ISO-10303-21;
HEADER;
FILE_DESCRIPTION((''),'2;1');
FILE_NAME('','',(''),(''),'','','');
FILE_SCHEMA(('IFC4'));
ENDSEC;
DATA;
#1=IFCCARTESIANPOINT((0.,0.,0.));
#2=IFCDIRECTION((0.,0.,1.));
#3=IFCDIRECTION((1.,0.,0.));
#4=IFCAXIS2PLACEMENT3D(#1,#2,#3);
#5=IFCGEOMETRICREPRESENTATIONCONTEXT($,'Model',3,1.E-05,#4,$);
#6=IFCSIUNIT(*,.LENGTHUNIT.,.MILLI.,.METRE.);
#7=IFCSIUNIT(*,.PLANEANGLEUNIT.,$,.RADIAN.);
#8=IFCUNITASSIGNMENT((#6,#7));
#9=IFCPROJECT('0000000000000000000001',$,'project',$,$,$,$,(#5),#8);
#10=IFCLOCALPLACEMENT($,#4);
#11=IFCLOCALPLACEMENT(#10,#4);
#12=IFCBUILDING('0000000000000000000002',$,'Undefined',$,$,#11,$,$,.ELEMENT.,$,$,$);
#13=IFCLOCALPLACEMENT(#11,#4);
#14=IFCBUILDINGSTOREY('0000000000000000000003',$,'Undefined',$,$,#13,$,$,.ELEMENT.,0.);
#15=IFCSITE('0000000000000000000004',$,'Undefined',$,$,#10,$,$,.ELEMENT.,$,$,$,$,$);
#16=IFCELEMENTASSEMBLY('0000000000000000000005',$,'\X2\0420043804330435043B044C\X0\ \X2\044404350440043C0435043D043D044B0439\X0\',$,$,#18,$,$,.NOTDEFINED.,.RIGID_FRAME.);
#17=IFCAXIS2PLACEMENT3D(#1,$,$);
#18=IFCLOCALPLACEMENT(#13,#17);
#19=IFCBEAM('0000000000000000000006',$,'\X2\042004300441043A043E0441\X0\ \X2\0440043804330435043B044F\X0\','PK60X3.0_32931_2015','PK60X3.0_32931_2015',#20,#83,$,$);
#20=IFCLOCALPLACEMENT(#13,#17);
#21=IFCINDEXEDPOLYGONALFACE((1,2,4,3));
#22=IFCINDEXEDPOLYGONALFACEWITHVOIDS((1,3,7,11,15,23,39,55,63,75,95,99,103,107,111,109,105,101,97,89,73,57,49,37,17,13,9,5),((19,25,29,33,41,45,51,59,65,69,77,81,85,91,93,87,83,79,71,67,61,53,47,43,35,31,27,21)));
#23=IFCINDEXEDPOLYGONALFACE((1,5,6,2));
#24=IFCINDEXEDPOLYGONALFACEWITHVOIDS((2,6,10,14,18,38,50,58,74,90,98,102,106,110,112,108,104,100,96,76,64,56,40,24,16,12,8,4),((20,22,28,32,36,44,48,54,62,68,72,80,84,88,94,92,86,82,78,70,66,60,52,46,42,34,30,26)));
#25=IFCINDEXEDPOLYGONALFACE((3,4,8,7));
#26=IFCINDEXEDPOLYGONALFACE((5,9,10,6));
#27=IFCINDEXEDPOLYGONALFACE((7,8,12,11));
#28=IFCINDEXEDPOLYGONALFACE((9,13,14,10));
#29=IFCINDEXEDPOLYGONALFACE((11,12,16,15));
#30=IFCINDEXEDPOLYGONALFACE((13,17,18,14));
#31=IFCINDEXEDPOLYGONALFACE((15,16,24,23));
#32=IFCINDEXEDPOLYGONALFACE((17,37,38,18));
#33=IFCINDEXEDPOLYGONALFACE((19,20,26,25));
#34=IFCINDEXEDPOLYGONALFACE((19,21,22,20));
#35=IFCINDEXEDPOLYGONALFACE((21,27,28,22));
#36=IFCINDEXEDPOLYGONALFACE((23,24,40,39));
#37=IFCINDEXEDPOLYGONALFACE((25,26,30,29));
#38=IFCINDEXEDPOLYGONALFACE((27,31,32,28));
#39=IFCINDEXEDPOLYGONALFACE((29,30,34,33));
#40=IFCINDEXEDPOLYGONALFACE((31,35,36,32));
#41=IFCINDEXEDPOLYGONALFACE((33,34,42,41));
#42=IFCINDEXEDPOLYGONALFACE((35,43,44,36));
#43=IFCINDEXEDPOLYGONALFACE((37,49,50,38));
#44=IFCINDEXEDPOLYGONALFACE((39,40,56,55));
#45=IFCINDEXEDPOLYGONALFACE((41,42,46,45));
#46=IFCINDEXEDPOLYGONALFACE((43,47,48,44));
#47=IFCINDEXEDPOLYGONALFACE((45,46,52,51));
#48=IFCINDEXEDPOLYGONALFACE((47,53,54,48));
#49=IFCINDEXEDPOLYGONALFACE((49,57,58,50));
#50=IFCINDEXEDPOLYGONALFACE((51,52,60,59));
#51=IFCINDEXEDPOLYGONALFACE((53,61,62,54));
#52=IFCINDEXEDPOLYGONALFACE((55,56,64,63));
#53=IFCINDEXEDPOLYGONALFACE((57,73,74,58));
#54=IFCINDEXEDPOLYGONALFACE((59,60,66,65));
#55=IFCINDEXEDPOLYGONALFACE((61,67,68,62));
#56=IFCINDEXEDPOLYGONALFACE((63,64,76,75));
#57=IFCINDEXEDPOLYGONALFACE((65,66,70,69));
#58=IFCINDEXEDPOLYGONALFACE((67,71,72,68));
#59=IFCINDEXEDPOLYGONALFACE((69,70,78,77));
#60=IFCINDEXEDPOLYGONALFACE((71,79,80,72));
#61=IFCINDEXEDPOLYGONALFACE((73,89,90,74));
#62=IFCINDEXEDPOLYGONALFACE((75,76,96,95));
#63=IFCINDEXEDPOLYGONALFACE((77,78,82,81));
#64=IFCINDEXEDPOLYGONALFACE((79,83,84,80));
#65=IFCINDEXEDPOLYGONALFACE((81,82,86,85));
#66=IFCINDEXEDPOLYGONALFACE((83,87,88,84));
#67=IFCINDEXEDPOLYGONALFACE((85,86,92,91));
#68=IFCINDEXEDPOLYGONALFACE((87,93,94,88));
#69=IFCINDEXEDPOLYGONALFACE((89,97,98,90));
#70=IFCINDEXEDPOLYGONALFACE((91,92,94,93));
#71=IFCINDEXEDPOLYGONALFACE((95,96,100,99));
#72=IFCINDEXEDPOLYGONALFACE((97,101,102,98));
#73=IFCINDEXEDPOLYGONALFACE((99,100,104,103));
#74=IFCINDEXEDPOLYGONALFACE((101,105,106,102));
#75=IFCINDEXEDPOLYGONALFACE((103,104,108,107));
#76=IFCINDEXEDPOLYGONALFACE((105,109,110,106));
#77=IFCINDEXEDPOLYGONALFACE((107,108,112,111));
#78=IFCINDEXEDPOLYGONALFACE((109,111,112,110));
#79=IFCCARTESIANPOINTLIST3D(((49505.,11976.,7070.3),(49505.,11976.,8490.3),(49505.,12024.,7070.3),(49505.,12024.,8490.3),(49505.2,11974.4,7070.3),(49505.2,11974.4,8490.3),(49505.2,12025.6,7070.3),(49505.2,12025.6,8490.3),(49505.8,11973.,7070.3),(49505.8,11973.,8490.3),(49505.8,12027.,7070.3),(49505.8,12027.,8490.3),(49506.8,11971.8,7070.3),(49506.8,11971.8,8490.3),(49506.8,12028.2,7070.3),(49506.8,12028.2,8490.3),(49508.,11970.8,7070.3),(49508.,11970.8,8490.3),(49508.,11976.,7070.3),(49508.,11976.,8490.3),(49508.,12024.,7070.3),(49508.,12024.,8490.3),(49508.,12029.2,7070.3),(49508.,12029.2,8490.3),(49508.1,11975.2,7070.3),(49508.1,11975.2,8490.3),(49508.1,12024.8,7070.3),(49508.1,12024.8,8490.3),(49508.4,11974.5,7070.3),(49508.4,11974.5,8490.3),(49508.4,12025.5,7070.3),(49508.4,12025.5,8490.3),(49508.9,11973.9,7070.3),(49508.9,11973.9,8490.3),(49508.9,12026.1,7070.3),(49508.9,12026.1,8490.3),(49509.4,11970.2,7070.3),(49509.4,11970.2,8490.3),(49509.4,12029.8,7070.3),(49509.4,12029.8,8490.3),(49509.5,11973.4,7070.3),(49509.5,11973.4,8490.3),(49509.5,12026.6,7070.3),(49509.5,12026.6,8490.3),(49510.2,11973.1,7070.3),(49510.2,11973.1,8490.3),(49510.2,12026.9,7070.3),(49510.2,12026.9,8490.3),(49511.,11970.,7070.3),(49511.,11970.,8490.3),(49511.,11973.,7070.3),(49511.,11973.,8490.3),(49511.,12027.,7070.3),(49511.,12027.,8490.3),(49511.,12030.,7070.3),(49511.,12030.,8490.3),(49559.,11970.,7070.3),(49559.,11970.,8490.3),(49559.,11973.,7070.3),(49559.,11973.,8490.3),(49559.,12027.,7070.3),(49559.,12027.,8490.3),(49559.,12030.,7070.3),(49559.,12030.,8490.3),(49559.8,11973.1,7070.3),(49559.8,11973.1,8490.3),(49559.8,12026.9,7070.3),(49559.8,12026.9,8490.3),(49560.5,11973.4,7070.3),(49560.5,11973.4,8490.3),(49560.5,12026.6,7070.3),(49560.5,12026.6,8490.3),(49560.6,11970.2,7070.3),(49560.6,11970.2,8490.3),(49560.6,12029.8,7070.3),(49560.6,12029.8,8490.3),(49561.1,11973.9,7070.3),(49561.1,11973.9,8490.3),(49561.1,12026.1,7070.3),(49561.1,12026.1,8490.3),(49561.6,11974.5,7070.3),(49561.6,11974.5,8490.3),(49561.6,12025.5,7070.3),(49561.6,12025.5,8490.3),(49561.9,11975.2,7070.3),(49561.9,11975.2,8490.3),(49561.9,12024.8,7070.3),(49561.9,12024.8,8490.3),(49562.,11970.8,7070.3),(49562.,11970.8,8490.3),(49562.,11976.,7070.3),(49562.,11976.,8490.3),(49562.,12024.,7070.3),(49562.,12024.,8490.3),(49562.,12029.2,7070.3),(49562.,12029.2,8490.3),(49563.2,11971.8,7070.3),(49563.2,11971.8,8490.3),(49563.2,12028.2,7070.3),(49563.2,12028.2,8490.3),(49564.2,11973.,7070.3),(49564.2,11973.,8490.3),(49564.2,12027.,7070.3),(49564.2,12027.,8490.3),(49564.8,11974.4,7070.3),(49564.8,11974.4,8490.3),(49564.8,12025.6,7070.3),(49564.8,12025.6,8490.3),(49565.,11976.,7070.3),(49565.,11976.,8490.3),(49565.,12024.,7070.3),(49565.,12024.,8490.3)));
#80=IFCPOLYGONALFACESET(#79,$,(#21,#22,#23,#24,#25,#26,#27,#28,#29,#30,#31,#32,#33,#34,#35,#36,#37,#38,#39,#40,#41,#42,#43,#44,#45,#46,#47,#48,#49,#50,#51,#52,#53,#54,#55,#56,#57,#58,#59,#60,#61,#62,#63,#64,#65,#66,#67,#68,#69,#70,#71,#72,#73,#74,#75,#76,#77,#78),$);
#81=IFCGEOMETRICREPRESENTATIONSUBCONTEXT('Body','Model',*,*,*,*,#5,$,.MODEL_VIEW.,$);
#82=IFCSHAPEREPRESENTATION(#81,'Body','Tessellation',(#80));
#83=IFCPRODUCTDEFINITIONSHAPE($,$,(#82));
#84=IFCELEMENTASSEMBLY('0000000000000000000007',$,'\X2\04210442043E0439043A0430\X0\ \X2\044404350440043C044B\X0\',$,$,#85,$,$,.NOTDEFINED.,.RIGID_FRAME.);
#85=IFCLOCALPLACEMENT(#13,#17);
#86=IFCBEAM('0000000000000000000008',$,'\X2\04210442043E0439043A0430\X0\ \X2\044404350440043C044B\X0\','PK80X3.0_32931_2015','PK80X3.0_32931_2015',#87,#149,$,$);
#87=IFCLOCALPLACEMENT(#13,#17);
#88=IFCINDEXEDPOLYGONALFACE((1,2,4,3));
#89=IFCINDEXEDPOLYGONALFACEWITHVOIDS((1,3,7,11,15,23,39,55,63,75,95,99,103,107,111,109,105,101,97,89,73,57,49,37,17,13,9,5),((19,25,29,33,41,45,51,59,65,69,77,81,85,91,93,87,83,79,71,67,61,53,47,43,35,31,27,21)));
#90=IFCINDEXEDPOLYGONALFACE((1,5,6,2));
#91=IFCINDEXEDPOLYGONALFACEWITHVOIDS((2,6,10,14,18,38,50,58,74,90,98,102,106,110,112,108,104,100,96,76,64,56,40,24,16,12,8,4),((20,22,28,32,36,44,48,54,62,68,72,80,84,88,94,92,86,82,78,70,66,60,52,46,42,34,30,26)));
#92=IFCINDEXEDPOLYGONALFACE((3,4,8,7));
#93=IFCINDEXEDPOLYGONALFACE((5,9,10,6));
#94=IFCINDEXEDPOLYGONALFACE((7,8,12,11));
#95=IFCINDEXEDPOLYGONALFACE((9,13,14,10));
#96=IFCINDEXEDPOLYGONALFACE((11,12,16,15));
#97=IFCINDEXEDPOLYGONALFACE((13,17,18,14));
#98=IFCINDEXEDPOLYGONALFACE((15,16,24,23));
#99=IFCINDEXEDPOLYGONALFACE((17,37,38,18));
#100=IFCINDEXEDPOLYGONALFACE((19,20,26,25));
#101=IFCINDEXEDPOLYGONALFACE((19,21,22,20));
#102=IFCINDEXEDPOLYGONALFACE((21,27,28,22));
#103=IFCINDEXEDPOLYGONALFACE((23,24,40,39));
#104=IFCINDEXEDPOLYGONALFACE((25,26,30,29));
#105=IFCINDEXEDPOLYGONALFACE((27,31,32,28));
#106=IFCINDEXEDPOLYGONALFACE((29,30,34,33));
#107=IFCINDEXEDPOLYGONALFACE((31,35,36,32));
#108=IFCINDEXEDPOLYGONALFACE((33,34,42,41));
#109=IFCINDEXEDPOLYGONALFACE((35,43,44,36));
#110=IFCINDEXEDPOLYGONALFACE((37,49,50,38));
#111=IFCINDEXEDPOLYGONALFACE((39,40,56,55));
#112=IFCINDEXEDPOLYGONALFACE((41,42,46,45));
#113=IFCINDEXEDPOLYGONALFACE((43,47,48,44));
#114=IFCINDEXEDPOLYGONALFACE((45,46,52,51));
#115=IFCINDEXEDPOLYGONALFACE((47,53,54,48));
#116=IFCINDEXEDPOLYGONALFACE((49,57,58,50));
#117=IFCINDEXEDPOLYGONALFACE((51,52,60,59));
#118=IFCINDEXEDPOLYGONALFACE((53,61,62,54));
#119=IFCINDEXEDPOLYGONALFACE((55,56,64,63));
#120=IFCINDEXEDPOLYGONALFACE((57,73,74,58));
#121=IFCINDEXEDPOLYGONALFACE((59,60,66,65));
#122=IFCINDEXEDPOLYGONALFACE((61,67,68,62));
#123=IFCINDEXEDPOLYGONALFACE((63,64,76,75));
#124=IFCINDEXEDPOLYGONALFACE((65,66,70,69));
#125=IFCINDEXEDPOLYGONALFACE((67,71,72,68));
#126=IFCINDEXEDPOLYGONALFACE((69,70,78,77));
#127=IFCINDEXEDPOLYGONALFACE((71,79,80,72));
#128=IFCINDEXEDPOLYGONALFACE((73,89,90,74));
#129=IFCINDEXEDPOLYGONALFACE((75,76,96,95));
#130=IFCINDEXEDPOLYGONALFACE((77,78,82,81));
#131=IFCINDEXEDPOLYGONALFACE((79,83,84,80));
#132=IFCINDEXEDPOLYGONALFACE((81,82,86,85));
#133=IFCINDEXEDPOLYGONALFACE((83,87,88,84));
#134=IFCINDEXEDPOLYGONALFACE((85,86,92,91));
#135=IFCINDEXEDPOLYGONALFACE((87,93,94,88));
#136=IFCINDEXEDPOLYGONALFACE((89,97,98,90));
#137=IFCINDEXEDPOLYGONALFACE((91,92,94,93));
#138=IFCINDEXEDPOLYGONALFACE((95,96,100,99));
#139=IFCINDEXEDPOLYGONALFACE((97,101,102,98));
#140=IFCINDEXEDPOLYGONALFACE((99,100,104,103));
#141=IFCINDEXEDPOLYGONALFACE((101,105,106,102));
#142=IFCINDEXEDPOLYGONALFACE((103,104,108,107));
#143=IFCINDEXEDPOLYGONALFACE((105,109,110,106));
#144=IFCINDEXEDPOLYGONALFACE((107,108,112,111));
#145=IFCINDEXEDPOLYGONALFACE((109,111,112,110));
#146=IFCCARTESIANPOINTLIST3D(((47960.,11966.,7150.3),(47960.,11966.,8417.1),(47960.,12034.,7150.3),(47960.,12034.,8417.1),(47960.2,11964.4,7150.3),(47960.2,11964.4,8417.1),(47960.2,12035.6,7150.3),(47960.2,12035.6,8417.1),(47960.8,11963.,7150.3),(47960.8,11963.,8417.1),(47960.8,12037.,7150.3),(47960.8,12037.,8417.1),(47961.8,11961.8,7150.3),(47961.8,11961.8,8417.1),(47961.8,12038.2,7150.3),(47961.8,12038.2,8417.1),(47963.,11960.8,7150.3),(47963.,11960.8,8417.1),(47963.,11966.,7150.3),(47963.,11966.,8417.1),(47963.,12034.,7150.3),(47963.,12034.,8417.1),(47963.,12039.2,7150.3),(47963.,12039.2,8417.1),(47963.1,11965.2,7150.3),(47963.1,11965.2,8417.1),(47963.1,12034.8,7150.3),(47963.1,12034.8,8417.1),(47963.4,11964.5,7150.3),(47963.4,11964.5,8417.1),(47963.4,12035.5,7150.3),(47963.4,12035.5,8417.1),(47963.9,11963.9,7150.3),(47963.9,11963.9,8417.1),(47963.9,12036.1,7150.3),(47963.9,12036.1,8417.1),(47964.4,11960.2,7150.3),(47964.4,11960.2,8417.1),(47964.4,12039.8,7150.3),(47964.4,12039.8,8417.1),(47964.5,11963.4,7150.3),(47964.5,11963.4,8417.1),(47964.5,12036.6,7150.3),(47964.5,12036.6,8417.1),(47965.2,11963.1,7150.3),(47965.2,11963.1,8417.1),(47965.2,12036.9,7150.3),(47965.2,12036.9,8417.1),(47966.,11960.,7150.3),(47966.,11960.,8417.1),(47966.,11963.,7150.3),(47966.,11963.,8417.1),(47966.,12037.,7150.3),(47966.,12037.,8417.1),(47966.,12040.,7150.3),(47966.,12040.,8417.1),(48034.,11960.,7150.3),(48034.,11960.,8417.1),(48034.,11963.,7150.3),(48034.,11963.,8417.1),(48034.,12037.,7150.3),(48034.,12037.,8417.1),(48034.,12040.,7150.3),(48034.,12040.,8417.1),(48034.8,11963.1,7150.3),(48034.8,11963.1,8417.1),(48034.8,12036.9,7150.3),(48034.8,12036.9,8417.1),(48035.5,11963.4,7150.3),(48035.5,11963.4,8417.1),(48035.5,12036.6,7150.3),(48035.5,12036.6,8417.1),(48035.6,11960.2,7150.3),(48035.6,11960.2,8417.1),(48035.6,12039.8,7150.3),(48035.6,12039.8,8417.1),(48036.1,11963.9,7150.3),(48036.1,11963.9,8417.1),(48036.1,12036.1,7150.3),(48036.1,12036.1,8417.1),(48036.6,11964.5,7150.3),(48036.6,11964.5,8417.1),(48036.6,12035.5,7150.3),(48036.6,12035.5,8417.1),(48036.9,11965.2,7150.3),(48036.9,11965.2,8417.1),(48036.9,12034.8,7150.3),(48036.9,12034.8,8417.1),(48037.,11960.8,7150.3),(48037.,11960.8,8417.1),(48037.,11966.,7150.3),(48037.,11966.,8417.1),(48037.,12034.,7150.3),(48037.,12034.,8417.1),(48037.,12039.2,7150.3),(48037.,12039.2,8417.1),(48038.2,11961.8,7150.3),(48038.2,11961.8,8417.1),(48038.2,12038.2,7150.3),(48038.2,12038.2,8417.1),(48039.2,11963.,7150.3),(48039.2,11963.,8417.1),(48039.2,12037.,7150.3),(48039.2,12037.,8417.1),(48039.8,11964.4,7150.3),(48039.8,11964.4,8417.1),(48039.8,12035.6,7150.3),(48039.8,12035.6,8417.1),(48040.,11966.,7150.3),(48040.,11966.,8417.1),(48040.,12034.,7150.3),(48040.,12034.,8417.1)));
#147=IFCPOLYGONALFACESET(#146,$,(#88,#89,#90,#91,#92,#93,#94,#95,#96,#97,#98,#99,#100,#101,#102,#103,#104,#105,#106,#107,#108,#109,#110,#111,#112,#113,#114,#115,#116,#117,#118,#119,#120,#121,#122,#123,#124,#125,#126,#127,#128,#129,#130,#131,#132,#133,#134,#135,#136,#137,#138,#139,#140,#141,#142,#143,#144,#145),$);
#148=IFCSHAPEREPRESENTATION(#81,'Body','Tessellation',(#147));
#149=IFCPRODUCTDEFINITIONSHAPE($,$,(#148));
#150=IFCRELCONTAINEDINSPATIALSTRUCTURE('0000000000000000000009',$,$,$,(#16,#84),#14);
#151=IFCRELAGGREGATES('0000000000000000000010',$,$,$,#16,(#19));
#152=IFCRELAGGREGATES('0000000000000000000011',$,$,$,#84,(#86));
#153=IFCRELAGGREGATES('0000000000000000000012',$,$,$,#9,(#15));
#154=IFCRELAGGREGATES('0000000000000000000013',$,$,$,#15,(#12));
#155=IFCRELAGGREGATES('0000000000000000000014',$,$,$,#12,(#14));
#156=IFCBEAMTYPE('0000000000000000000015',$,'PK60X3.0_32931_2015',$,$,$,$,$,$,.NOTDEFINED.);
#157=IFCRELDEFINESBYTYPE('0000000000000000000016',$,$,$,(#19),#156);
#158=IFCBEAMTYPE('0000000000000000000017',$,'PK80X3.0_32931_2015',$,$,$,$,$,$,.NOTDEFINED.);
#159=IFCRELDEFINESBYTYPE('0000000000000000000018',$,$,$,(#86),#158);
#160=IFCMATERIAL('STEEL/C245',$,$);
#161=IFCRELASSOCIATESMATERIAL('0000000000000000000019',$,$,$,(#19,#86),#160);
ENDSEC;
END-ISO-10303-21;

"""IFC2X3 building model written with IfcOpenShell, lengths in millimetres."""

from ifc_helpers import new_model, si_unit, frame, origin_with_axes, origin_2d_with_axis, place, context, subcontext, project, spatial, hollow_rectangle, extrude, material, type_object, element, aggregate, save


model = new_model("IFC2X3")

# Units and contexts
model_context = context("Model", 3, precision=1e-05, world=origin_with_axes())
body_context = subcontext(model_context, "Body", "Model", "MODEL_VIEW")
ifc_project = project(units=[si_unit("LENGTHUNIT", "METRE", prefix="MILLI"), si_unit("PLANEANGLEUNIT", "RADIAN")], contexts=[model_context])

# Site, building, storey
site_placement = place(None, origin_with_axes())
site = spatial("IfcSite", under=ifc_project, at=site_placement, Name="Undefined", CompositionType="ELEMENT")
building_placement = place(site_placement, origin_with_axes())
building = spatial("IfcBuilding", under=site, at=building_placement, Name="Undefined", CompositionType="ELEMENT")
storey_placement = place(building_placement, origin_with_axes())
storey = spatial("IfcBuildingStorey", under=building, at=storey_placement, Name="Undefined", CompositionType="ELEMENT", Elevation=0.0)

# Shared definitions
ifc_material_1 = material(Name="STEEL/C245")

# Element assembly, beam
assembly_1_placement = place(storey_placement, origin_with_axes())
assembly_1 = element("IfcElementAssembly", 1, at=assembly_1_placement, inside=storey, Name="Ригель ферменный", AssemblyPlace="NOTDEFINED", PredefinedType="RIGID_FRAME")
beam_type_1 = type_object("IfcBeamType", Name="PK60X3.0_32931_2015", PredefinedType="NOTDEFINED")
beam_1_placement = place(assembly_1_placement, frame((49535.0, 12000.0, 8490.3), z_axis=(1.0, 0.0, 0.0), x_axis=(0.0, 0.0, -1.0)))
beam_1 = element("IfcBeam", 2, at=beam_1_placement, type_object=beam_type_1, material=ifc_material_1, Name="Раскос ригеля", Description="PK60X3.0_32931_2015", ObjectType="PK60X3.0_32931_2015", context=body_context, shape_type="SweptSolid", body=[
    extrude(hollow_rectangle(XDim=60.0, YDim=60.0, WallThickness=3.0, InnerFilletRadius=3.0, OuterFilletRadius=6.0, at=origin_2d_with_axis()), frame((1420.0, 0.0, 0.0), z_axis=(-1.0, 0.0, 0.0), x_axis=(0.0, -1.0, 0.0)), (0.0, 0.0, 1.0), 1420.0),
])
aggregate(assembly_1, [beam_1])

# Element assembly, beam
assembly_2_placement = place(storey_placement, origin_with_axes())
assembly_2 = element("IfcElementAssembly", 3, at=assembly_2_placement, inside=storey, Name="Стойка фермы", AssemblyPlace="NOTDEFINED", PredefinedType="RIGID_FRAME")
beam_type_2 = type_object("IfcBeamType", Name="PK80X3.0_32931_2015", PredefinedType="NOTDEFINED")
beam_2_placement = place(assembly_2_placement, frame((48000.0, 12000.0, 8417.1), z_axis=(1.0, 0.0, 0.0), x_axis=(0.0, 0.0, -1.0)))
beam_2 = element("IfcBeam", 4, at=beam_2_placement, type_object=beam_type_2, material=ifc_material_1, Name="Стойка фермы", Description="PK80X3.0_32931_2015", ObjectType="PK80X3.0_32931_2015", context=body_context, shape_type="SweptSolid", body=[
    extrude(hollow_rectangle(XDim=80.0, YDim=80.0, WallThickness=3.0, InnerFilletRadius=3.0, OuterFilletRadius=6.0, at=origin_2d_with_axis()), frame((1266.8, 0.0, 0.0), z_axis=(-1.0, 0.0, 0.0), x_axis=(0.0, -1.0, 0.0)), (0.0, 0.0, 1.0), 1266.8),
])
aggregate(assembly_2, [beam_2])

save(model, "model.ifc")
